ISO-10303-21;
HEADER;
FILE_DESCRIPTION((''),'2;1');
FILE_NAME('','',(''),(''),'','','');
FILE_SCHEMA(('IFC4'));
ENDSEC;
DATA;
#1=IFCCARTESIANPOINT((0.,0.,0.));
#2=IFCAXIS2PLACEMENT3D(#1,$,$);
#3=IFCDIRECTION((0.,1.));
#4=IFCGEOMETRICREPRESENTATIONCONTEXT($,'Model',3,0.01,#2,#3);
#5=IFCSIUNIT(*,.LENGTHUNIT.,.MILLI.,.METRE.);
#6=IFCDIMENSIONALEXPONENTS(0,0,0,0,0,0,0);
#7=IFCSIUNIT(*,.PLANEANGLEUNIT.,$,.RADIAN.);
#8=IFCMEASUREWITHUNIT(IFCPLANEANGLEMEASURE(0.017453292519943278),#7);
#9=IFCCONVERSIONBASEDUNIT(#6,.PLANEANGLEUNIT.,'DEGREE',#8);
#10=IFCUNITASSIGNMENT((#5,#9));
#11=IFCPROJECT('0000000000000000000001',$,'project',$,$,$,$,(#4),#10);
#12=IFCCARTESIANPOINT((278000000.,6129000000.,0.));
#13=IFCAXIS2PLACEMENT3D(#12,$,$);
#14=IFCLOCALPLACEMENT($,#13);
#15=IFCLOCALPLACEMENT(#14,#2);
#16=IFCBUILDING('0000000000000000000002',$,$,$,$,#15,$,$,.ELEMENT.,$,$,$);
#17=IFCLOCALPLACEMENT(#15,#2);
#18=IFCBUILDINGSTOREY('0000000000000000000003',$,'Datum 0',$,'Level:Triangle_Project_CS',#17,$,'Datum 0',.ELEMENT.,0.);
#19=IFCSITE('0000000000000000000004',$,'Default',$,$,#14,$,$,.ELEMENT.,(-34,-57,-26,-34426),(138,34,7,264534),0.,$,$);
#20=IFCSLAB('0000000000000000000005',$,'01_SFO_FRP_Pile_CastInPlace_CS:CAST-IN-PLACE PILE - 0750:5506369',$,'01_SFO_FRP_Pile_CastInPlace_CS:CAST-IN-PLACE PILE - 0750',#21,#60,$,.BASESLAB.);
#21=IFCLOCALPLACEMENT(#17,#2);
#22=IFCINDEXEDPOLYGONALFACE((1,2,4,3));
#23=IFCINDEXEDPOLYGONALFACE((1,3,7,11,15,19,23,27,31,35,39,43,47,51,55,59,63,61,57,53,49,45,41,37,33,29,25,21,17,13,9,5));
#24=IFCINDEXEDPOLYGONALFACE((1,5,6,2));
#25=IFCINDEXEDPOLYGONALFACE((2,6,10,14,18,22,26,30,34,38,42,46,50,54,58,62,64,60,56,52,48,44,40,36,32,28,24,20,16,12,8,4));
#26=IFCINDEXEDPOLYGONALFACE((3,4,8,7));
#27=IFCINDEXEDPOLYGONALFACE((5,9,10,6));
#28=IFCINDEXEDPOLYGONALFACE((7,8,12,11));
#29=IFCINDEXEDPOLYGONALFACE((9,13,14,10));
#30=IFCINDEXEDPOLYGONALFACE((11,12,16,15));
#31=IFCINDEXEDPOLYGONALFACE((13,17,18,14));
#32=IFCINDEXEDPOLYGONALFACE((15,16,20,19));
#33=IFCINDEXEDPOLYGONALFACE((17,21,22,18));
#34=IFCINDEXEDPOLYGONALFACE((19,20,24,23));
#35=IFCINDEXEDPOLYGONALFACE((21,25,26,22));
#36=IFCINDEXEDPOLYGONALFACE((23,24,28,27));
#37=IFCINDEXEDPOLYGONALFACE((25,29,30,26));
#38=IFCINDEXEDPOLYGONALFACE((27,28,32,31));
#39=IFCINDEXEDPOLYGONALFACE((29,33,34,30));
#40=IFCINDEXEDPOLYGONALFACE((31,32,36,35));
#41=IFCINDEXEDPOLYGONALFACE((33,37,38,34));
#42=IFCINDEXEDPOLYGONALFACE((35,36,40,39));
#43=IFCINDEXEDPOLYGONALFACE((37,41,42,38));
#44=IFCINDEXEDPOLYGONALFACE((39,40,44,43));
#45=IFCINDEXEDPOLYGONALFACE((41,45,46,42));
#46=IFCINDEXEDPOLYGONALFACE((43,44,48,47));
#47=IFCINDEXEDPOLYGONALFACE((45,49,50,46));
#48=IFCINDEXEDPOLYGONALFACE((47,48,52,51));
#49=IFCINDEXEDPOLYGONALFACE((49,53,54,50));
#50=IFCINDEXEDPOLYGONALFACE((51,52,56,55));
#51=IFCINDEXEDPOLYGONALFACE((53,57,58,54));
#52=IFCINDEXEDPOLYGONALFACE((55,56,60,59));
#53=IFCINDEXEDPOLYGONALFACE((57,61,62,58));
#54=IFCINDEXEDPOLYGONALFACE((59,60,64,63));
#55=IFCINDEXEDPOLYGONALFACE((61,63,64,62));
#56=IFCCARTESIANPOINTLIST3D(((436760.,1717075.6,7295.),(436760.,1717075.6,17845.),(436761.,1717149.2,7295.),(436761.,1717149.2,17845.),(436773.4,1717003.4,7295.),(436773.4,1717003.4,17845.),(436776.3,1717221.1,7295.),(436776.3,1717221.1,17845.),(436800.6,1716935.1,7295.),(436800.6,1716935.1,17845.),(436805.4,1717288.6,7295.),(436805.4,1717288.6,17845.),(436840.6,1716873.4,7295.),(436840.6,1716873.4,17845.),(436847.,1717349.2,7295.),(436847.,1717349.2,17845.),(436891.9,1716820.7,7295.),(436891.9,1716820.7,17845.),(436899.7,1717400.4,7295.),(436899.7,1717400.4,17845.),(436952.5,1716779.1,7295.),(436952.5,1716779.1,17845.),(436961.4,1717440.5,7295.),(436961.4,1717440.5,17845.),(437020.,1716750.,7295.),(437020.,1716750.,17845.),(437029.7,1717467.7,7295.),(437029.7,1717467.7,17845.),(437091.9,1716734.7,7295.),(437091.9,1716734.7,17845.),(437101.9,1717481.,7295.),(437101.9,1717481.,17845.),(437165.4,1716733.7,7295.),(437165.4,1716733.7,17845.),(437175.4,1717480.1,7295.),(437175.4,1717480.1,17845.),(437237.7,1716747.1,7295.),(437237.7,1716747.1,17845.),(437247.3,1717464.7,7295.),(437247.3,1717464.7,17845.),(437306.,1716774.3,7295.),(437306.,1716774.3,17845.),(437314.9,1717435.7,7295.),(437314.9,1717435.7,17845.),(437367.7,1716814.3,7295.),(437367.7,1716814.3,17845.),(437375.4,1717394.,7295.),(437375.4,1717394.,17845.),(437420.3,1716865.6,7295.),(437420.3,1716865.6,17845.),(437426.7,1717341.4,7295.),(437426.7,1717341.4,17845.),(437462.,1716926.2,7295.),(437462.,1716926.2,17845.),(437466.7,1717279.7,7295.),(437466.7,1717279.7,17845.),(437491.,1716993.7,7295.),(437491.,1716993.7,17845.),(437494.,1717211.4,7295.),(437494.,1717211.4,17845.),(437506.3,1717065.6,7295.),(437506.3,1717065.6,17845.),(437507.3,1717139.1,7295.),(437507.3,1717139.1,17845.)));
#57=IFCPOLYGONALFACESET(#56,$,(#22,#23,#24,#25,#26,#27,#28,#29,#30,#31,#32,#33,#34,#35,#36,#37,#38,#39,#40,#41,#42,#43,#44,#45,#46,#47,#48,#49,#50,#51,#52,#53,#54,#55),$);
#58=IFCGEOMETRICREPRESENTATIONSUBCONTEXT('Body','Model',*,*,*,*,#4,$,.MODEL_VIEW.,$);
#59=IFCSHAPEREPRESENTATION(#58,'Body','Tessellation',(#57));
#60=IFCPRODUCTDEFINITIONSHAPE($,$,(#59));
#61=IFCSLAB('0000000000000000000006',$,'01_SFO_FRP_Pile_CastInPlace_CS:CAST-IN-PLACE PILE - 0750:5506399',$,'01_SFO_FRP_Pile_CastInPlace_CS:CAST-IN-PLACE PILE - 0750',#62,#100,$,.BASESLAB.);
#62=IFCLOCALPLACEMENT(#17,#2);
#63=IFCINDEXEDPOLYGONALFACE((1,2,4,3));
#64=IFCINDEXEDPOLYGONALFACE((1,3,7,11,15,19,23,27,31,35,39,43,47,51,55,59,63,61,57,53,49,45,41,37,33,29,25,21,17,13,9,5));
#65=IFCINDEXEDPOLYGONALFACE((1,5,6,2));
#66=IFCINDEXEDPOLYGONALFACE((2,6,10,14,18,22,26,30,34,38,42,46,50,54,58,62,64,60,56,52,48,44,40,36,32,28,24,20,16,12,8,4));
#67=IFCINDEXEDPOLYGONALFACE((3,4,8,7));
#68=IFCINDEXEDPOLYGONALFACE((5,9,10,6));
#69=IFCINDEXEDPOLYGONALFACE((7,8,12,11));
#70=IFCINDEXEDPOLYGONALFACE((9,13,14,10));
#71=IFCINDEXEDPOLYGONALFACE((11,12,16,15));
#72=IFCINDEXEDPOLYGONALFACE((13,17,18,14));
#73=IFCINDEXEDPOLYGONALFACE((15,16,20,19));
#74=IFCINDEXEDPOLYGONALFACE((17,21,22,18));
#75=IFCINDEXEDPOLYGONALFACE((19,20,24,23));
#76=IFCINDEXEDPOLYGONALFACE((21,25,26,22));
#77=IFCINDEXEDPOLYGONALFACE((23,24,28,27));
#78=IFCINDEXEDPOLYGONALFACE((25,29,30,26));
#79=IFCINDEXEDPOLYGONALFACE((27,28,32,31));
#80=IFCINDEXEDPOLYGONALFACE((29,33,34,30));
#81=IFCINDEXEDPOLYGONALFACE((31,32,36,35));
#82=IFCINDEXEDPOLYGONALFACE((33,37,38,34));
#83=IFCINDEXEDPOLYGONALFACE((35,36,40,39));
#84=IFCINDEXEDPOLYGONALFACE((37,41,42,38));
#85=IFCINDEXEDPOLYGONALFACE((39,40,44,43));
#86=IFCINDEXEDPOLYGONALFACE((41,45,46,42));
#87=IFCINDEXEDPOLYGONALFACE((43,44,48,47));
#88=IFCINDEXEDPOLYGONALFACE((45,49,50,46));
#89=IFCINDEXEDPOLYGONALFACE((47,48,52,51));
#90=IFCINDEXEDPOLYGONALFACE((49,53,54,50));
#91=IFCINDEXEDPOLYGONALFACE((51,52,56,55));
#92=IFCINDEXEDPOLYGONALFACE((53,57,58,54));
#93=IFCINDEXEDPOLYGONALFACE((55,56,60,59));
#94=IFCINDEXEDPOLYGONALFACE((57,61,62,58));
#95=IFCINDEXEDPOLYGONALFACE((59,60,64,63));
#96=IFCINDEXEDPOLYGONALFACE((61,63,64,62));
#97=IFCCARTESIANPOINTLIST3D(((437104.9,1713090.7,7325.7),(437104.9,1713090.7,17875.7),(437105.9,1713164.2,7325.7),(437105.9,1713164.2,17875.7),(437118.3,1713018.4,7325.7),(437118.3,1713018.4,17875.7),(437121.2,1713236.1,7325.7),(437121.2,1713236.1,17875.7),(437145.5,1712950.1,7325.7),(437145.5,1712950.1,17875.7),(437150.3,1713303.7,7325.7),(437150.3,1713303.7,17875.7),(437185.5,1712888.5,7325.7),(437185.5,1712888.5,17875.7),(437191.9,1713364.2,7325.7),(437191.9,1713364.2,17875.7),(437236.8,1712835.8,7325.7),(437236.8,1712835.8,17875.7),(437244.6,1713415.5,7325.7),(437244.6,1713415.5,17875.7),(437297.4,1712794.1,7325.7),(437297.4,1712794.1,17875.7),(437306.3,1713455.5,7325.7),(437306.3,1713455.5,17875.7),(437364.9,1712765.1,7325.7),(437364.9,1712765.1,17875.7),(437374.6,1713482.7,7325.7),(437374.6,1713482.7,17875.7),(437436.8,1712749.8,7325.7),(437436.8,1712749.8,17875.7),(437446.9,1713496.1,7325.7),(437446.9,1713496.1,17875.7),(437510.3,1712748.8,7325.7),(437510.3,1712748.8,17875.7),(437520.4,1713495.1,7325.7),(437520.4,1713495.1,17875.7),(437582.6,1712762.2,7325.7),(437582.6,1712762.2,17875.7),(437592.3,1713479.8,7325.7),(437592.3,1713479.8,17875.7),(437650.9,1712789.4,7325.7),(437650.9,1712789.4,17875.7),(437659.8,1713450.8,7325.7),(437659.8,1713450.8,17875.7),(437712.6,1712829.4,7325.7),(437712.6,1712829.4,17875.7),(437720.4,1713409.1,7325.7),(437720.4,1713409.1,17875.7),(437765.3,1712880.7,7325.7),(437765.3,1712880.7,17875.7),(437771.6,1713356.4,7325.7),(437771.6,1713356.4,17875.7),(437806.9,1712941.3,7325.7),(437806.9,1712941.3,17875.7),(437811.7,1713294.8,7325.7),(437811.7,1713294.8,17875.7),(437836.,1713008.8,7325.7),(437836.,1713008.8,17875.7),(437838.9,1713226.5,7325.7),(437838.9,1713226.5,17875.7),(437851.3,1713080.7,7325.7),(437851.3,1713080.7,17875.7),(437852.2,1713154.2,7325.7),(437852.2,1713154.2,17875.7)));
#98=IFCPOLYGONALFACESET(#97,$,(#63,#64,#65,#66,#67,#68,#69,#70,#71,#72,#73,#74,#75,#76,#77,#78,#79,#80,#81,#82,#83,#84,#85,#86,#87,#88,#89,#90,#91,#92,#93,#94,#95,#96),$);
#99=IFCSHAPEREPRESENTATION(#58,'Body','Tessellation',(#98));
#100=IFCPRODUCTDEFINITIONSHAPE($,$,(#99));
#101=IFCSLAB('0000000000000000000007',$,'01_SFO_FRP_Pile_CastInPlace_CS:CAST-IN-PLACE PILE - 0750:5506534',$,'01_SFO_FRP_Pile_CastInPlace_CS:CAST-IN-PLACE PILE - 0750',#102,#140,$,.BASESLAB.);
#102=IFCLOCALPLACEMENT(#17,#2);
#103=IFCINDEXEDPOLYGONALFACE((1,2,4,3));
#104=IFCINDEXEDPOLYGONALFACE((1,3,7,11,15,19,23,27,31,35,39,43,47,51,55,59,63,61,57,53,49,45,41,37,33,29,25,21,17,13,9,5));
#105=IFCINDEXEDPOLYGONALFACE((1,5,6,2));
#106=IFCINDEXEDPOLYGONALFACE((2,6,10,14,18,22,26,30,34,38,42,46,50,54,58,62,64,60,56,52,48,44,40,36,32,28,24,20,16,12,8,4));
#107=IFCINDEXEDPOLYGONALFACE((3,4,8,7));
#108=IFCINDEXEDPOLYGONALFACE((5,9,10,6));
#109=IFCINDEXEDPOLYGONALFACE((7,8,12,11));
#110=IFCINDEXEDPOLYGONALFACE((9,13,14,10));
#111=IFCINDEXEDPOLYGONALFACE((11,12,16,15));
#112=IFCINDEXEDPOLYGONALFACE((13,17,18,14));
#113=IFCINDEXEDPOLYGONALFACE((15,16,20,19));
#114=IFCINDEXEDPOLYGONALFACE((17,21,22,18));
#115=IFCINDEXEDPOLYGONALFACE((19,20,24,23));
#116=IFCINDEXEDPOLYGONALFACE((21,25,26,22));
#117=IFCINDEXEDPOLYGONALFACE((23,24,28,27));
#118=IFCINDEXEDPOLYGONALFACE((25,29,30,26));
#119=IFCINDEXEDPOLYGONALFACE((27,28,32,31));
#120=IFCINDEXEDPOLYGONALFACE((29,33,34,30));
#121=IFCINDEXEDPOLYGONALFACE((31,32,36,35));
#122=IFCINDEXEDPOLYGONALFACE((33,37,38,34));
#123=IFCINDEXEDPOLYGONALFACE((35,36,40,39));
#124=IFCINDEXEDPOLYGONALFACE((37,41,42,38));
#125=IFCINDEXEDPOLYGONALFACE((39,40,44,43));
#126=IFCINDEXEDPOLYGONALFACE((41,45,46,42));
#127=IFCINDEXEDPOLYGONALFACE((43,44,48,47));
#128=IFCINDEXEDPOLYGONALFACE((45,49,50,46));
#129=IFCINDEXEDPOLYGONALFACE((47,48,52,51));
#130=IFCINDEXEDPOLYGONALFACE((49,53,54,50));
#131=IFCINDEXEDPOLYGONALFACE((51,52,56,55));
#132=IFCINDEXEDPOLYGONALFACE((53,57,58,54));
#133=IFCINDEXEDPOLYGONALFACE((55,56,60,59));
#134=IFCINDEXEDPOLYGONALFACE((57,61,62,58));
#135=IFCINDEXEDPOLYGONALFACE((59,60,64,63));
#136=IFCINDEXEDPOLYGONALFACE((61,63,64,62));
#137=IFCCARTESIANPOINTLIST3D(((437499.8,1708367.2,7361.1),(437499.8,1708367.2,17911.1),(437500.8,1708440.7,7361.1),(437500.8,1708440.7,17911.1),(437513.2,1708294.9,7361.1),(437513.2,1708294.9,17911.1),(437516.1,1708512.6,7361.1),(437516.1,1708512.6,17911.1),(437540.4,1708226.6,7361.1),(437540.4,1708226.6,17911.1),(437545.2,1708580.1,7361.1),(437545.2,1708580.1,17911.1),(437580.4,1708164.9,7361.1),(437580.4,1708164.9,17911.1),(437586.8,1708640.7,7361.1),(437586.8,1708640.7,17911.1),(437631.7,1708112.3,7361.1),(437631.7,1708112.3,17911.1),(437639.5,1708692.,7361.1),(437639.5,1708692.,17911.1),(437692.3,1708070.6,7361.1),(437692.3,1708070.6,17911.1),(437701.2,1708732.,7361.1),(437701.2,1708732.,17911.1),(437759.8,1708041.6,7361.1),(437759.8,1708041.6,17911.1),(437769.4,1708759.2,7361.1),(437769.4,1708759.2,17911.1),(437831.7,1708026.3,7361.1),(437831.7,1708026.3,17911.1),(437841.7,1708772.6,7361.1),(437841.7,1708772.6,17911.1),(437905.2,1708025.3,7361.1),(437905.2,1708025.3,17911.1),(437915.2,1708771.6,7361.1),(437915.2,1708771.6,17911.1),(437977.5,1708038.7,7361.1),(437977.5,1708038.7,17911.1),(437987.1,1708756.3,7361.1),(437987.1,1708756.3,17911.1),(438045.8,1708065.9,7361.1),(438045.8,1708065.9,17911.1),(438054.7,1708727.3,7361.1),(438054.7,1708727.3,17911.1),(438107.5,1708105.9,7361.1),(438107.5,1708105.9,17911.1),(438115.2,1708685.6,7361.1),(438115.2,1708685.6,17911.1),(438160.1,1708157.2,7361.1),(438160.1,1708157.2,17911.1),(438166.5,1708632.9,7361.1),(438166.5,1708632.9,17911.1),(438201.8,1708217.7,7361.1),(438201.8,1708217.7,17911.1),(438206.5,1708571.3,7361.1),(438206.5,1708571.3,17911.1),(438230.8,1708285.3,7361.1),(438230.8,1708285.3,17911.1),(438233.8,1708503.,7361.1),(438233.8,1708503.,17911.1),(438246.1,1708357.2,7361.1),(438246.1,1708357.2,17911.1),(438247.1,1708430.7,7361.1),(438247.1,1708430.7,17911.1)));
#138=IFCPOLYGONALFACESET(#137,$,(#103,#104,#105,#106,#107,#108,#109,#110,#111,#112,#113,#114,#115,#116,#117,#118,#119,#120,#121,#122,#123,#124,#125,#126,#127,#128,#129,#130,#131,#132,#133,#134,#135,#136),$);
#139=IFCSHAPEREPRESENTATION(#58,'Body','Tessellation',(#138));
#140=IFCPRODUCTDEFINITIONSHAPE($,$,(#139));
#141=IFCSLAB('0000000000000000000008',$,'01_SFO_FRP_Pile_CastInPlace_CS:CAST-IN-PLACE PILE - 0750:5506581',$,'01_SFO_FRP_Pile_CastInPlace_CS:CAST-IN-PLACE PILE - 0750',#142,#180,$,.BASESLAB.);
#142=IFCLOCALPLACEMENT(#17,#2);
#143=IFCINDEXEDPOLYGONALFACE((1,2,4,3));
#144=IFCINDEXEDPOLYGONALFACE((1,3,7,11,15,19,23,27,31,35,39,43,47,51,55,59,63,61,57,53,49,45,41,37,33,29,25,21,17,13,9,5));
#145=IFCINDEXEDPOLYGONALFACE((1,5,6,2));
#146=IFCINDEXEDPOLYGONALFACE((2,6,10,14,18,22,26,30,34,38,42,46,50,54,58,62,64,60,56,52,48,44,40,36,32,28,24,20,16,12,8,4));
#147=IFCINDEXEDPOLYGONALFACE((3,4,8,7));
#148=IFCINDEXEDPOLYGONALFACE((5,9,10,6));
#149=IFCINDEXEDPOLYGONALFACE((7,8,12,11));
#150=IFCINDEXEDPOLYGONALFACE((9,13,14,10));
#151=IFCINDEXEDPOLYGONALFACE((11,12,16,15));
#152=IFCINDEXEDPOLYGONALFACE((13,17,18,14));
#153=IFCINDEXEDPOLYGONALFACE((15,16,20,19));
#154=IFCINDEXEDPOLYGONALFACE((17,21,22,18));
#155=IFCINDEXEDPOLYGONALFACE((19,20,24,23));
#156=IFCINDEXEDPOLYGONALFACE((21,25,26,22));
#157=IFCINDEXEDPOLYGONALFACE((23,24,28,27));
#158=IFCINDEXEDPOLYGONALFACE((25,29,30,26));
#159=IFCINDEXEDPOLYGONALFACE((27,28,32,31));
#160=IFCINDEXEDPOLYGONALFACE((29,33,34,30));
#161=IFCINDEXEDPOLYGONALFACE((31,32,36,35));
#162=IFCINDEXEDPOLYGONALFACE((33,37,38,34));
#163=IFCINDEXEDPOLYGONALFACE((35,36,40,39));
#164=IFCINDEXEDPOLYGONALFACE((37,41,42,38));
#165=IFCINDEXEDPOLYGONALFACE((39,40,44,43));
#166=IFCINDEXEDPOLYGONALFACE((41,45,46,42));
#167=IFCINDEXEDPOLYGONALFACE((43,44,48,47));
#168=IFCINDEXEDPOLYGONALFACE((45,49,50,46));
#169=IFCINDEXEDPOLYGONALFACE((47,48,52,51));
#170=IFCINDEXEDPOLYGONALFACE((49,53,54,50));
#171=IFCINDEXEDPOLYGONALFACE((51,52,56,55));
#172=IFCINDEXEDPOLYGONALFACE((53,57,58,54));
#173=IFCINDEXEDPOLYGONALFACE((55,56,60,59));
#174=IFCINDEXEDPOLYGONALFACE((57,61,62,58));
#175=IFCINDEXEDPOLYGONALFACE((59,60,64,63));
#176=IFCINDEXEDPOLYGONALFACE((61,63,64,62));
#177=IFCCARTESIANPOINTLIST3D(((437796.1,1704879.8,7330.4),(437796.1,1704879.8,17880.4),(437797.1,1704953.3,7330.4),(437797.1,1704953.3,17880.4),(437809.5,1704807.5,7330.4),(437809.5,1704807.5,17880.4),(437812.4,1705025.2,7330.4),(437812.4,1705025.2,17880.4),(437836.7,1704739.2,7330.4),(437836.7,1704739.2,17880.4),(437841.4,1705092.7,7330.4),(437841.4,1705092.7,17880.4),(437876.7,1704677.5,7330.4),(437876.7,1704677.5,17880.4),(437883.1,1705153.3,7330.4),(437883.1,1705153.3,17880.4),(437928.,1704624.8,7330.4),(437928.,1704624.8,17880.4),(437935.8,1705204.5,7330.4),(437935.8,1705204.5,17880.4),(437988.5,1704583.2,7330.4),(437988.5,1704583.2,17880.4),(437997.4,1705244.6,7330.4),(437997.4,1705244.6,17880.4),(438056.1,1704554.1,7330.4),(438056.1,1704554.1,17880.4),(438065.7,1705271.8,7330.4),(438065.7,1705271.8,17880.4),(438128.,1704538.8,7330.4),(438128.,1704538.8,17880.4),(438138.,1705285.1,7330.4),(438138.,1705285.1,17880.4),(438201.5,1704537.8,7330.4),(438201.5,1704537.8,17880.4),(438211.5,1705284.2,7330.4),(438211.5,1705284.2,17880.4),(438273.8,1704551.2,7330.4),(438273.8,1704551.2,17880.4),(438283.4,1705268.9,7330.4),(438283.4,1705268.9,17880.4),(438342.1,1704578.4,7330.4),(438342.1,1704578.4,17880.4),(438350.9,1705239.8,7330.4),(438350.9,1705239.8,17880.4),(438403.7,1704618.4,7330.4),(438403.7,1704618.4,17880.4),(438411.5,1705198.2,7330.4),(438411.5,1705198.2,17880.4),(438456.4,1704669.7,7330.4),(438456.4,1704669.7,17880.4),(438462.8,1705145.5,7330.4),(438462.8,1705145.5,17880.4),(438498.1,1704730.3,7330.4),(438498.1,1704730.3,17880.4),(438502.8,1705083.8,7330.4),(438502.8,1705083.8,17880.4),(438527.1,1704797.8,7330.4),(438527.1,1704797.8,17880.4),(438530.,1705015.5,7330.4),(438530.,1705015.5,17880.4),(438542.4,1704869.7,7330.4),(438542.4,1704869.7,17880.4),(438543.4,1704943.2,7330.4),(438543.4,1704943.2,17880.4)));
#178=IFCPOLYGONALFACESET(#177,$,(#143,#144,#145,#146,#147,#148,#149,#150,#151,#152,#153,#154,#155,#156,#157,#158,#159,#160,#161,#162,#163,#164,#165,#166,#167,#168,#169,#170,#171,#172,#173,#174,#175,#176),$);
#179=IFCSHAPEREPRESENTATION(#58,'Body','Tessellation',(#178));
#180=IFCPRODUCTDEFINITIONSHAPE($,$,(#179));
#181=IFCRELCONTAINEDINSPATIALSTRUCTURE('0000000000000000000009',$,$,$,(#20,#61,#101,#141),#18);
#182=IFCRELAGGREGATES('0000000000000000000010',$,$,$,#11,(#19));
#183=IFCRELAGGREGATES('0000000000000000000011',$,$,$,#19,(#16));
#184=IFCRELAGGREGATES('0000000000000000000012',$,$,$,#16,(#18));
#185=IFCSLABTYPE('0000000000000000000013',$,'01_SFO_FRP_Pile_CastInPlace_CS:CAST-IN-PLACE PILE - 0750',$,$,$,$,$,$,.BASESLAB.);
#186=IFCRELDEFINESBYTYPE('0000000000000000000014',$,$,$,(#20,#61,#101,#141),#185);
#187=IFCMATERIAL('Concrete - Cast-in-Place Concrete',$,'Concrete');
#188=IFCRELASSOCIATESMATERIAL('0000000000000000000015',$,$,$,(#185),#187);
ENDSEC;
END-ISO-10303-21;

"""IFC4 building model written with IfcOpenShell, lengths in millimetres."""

from ifc_helpers import new_model, entity, si_unit, converted_unit, direction, frame, origin, place, context, subcontext, project, spatial, arc, indexed_curve, outline, extrude, material, type_object, element, save


model = new_model("IFC4")

# Units and contexts
model_context = context("Model", 3, precision=0.01, world=origin(), true_north=direction((0.0, 1.0)))
body_context = subcontext(model_context, "Body", "Model", "MODEL_VIEW")
ifc_project = project(units=[si_unit("LENGTHUNIT", "METRE", prefix="MILLI"), converted_unit("PLANEANGLEUNIT", "DEGREE", entity("IfcPlaneAngleMeasure", 0.017453292519943278), si_unit("PLANEANGLEUNIT", "RADIAN"), dimensions=[0, 0, 0, 0, 0, 0, 0])], contexts=[model_context])

# Site, building, storey
site_placement = place(None, frame((278000000.0, 6129000000.0, 0.0)))
site = spatial("IfcSite", under=ifc_project, at=site_placement, Name="Default", CompositionType="ELEMENT", RefLatitude=(-34, -57, -26, -34426), RefLongitude=(138, 34, 7, 264534), RefElevation=0.0)
building_placement = place(site_placement, origin())
building = spatial("IfcBuilding", under=site, at=building_placement, CompositionType="ELEMENT")
storey_placement = place(building_placement, frame((0.0, 0.0, 0.0)))
storey = spatial("IfcBuildingStorey", under=building, at=storey_placement, Name="Datum 0", ObjectType="Level:Triangle_Project_CS", LongName="Datum 0", CompositionType="ELEMENT", Elevation=0.0)

# Shared definitions
ifc_material_1 = material(Name="Concrete - Cast-in-Place Concrete", Category="Concrete")

# Slabs
slab_type_1 = type_object("IfcSlabType", Name="01_SFO_FRP_Pile_CastInPlace_CS:CAST-IN-PLACE PILE - 0750", PredefinedType="BASESLAB", material=ifc_material_1)
slab_1_placement = place(storey_placement, origin())
element("IfcSlab", 1, at=slab_1_placement, inside=storey, type_object=slab_type_1, Name="01_SFO_FRP_Pile_CastInPlace_CS:CAST-IN-PLACE PILE - 0750:5506369", ObjectType="01_SFO_FRP_Pile_CastInPlace_CS:CAST-IN-PLACE PILE - 0750", PredefinedType="BASESLAB", context=body_context, shape_type="SweptSolid", body=[
    extrude(outline(indexed_curve([(-375.0, 0.0), (0.0, -375.0), (375.0, 0.0), (0.0, 375.0)], segments=[arc(1, 2, 3), arc(3, 4, 1)], self_intersect=False)), frame((437133.7, 1717107.4, 7295.0), z_axis=(0.0, 0.0, 1.0), x_axis=(-0.996411, -0.084646, 0.0)), (0.0, 0.0, 1.0), 10550.0),
])
slab_2_placement = place(storey_placement, origin())
element("IfcSlab", 2, at=slab_2_placement, inside=storey, type_object=slab_type_1, Name="01_SFO_FRP_Pile_CastInPlace_CS:CAST-IN-PLACE PILE - 0750:5506399", ObjectType="01_SFO_FRP_Pile_CastInPlace_CS:CAST-IN-PLACE PILE - 0750", PredefinedType="BASESLAB", context=body_context, shape_type="SweptSolid", body=[
    extrude(outline(indexed_curve([(-375.0, 0.0), (0.0, -375.0), (375.0, 0.0), (0.0, 375.0)], segments=[arc(1, 2, 3), arc(3, 4, 1)], self_intersect=False)), frame((437478.6, 1713122.5, 7325.7), z_axis=(0.0, 0.0, 1.0), x_axis=(-0.996411, -0.084646, 0.0)), (0.0, 0.0, 1.0), 10550.0),
])
slab_3_placement = place(storey_placement, origin())
element("IfcSlab", 3, at=slab_3_placement, inside=storey, type_object=slab_type_1, Name="01_SFO_FRP_Pile_CastInPlace_CS:CAST-IN-PLACE PILE - 0750:5506534", ObjectType="01_SFO_FRP_Pile_CastInPlace_CS:CAST-IN-PLACE PILE - 0750", PredefinedType="BASESLAB", context=body_context, shape_type="SweptSolid", body=[
    extrude(outline(indexed_curve([(-375.0, 0.0), (0.0, -375.0), (375.0, 0.0), (0.0, 375.0)], segments=[arc(1, 2, 3), arc(3, 4, 1)], self_intersect=False)), frame((437873.5, 1708398.9, 7361.1), z_axis=(0.0, 0.0, 1.0), x_axis=(-0.996411, -0.084646, 0.0)), (0.0, 0.0, 1.0), 10550.0),
])
slab_4_placement = place(storey_placement, origin())
element("IfcSlab", 4, at=slab_4_placement, inside=storey, type_object=slab_type_1, Name="01_SFO_FRP_Pile_CastInPlace_CS:CAST-IN-PLACE PILE - 0750:5506581", ObjectType="01_SFO_FRP_Pile_CastInPlace_CS:CAST-IN-PLACE PILE - 0750", PredefinedType="BASESLAB", context=body_context, shape_type="SweptSolid", body=[
    extrude(outline(indexed_curve([(-375.0, 0.0), (0.0, -375.0), (375.0, 0.0), (0.0, 375.0)], segments=[arc(1, 2, 3), arc(3, 4, 1)], self_intersect=False)), frame((438169.7, 1704911.5, 7330.4), z_axis=(0.0, 0.0, 1.0), x_axis=(-0.996411, -0.084646, 0.0)), (0.0, 0.0, 1.0), 10550.0),
])

save(model, "model.ifc")
